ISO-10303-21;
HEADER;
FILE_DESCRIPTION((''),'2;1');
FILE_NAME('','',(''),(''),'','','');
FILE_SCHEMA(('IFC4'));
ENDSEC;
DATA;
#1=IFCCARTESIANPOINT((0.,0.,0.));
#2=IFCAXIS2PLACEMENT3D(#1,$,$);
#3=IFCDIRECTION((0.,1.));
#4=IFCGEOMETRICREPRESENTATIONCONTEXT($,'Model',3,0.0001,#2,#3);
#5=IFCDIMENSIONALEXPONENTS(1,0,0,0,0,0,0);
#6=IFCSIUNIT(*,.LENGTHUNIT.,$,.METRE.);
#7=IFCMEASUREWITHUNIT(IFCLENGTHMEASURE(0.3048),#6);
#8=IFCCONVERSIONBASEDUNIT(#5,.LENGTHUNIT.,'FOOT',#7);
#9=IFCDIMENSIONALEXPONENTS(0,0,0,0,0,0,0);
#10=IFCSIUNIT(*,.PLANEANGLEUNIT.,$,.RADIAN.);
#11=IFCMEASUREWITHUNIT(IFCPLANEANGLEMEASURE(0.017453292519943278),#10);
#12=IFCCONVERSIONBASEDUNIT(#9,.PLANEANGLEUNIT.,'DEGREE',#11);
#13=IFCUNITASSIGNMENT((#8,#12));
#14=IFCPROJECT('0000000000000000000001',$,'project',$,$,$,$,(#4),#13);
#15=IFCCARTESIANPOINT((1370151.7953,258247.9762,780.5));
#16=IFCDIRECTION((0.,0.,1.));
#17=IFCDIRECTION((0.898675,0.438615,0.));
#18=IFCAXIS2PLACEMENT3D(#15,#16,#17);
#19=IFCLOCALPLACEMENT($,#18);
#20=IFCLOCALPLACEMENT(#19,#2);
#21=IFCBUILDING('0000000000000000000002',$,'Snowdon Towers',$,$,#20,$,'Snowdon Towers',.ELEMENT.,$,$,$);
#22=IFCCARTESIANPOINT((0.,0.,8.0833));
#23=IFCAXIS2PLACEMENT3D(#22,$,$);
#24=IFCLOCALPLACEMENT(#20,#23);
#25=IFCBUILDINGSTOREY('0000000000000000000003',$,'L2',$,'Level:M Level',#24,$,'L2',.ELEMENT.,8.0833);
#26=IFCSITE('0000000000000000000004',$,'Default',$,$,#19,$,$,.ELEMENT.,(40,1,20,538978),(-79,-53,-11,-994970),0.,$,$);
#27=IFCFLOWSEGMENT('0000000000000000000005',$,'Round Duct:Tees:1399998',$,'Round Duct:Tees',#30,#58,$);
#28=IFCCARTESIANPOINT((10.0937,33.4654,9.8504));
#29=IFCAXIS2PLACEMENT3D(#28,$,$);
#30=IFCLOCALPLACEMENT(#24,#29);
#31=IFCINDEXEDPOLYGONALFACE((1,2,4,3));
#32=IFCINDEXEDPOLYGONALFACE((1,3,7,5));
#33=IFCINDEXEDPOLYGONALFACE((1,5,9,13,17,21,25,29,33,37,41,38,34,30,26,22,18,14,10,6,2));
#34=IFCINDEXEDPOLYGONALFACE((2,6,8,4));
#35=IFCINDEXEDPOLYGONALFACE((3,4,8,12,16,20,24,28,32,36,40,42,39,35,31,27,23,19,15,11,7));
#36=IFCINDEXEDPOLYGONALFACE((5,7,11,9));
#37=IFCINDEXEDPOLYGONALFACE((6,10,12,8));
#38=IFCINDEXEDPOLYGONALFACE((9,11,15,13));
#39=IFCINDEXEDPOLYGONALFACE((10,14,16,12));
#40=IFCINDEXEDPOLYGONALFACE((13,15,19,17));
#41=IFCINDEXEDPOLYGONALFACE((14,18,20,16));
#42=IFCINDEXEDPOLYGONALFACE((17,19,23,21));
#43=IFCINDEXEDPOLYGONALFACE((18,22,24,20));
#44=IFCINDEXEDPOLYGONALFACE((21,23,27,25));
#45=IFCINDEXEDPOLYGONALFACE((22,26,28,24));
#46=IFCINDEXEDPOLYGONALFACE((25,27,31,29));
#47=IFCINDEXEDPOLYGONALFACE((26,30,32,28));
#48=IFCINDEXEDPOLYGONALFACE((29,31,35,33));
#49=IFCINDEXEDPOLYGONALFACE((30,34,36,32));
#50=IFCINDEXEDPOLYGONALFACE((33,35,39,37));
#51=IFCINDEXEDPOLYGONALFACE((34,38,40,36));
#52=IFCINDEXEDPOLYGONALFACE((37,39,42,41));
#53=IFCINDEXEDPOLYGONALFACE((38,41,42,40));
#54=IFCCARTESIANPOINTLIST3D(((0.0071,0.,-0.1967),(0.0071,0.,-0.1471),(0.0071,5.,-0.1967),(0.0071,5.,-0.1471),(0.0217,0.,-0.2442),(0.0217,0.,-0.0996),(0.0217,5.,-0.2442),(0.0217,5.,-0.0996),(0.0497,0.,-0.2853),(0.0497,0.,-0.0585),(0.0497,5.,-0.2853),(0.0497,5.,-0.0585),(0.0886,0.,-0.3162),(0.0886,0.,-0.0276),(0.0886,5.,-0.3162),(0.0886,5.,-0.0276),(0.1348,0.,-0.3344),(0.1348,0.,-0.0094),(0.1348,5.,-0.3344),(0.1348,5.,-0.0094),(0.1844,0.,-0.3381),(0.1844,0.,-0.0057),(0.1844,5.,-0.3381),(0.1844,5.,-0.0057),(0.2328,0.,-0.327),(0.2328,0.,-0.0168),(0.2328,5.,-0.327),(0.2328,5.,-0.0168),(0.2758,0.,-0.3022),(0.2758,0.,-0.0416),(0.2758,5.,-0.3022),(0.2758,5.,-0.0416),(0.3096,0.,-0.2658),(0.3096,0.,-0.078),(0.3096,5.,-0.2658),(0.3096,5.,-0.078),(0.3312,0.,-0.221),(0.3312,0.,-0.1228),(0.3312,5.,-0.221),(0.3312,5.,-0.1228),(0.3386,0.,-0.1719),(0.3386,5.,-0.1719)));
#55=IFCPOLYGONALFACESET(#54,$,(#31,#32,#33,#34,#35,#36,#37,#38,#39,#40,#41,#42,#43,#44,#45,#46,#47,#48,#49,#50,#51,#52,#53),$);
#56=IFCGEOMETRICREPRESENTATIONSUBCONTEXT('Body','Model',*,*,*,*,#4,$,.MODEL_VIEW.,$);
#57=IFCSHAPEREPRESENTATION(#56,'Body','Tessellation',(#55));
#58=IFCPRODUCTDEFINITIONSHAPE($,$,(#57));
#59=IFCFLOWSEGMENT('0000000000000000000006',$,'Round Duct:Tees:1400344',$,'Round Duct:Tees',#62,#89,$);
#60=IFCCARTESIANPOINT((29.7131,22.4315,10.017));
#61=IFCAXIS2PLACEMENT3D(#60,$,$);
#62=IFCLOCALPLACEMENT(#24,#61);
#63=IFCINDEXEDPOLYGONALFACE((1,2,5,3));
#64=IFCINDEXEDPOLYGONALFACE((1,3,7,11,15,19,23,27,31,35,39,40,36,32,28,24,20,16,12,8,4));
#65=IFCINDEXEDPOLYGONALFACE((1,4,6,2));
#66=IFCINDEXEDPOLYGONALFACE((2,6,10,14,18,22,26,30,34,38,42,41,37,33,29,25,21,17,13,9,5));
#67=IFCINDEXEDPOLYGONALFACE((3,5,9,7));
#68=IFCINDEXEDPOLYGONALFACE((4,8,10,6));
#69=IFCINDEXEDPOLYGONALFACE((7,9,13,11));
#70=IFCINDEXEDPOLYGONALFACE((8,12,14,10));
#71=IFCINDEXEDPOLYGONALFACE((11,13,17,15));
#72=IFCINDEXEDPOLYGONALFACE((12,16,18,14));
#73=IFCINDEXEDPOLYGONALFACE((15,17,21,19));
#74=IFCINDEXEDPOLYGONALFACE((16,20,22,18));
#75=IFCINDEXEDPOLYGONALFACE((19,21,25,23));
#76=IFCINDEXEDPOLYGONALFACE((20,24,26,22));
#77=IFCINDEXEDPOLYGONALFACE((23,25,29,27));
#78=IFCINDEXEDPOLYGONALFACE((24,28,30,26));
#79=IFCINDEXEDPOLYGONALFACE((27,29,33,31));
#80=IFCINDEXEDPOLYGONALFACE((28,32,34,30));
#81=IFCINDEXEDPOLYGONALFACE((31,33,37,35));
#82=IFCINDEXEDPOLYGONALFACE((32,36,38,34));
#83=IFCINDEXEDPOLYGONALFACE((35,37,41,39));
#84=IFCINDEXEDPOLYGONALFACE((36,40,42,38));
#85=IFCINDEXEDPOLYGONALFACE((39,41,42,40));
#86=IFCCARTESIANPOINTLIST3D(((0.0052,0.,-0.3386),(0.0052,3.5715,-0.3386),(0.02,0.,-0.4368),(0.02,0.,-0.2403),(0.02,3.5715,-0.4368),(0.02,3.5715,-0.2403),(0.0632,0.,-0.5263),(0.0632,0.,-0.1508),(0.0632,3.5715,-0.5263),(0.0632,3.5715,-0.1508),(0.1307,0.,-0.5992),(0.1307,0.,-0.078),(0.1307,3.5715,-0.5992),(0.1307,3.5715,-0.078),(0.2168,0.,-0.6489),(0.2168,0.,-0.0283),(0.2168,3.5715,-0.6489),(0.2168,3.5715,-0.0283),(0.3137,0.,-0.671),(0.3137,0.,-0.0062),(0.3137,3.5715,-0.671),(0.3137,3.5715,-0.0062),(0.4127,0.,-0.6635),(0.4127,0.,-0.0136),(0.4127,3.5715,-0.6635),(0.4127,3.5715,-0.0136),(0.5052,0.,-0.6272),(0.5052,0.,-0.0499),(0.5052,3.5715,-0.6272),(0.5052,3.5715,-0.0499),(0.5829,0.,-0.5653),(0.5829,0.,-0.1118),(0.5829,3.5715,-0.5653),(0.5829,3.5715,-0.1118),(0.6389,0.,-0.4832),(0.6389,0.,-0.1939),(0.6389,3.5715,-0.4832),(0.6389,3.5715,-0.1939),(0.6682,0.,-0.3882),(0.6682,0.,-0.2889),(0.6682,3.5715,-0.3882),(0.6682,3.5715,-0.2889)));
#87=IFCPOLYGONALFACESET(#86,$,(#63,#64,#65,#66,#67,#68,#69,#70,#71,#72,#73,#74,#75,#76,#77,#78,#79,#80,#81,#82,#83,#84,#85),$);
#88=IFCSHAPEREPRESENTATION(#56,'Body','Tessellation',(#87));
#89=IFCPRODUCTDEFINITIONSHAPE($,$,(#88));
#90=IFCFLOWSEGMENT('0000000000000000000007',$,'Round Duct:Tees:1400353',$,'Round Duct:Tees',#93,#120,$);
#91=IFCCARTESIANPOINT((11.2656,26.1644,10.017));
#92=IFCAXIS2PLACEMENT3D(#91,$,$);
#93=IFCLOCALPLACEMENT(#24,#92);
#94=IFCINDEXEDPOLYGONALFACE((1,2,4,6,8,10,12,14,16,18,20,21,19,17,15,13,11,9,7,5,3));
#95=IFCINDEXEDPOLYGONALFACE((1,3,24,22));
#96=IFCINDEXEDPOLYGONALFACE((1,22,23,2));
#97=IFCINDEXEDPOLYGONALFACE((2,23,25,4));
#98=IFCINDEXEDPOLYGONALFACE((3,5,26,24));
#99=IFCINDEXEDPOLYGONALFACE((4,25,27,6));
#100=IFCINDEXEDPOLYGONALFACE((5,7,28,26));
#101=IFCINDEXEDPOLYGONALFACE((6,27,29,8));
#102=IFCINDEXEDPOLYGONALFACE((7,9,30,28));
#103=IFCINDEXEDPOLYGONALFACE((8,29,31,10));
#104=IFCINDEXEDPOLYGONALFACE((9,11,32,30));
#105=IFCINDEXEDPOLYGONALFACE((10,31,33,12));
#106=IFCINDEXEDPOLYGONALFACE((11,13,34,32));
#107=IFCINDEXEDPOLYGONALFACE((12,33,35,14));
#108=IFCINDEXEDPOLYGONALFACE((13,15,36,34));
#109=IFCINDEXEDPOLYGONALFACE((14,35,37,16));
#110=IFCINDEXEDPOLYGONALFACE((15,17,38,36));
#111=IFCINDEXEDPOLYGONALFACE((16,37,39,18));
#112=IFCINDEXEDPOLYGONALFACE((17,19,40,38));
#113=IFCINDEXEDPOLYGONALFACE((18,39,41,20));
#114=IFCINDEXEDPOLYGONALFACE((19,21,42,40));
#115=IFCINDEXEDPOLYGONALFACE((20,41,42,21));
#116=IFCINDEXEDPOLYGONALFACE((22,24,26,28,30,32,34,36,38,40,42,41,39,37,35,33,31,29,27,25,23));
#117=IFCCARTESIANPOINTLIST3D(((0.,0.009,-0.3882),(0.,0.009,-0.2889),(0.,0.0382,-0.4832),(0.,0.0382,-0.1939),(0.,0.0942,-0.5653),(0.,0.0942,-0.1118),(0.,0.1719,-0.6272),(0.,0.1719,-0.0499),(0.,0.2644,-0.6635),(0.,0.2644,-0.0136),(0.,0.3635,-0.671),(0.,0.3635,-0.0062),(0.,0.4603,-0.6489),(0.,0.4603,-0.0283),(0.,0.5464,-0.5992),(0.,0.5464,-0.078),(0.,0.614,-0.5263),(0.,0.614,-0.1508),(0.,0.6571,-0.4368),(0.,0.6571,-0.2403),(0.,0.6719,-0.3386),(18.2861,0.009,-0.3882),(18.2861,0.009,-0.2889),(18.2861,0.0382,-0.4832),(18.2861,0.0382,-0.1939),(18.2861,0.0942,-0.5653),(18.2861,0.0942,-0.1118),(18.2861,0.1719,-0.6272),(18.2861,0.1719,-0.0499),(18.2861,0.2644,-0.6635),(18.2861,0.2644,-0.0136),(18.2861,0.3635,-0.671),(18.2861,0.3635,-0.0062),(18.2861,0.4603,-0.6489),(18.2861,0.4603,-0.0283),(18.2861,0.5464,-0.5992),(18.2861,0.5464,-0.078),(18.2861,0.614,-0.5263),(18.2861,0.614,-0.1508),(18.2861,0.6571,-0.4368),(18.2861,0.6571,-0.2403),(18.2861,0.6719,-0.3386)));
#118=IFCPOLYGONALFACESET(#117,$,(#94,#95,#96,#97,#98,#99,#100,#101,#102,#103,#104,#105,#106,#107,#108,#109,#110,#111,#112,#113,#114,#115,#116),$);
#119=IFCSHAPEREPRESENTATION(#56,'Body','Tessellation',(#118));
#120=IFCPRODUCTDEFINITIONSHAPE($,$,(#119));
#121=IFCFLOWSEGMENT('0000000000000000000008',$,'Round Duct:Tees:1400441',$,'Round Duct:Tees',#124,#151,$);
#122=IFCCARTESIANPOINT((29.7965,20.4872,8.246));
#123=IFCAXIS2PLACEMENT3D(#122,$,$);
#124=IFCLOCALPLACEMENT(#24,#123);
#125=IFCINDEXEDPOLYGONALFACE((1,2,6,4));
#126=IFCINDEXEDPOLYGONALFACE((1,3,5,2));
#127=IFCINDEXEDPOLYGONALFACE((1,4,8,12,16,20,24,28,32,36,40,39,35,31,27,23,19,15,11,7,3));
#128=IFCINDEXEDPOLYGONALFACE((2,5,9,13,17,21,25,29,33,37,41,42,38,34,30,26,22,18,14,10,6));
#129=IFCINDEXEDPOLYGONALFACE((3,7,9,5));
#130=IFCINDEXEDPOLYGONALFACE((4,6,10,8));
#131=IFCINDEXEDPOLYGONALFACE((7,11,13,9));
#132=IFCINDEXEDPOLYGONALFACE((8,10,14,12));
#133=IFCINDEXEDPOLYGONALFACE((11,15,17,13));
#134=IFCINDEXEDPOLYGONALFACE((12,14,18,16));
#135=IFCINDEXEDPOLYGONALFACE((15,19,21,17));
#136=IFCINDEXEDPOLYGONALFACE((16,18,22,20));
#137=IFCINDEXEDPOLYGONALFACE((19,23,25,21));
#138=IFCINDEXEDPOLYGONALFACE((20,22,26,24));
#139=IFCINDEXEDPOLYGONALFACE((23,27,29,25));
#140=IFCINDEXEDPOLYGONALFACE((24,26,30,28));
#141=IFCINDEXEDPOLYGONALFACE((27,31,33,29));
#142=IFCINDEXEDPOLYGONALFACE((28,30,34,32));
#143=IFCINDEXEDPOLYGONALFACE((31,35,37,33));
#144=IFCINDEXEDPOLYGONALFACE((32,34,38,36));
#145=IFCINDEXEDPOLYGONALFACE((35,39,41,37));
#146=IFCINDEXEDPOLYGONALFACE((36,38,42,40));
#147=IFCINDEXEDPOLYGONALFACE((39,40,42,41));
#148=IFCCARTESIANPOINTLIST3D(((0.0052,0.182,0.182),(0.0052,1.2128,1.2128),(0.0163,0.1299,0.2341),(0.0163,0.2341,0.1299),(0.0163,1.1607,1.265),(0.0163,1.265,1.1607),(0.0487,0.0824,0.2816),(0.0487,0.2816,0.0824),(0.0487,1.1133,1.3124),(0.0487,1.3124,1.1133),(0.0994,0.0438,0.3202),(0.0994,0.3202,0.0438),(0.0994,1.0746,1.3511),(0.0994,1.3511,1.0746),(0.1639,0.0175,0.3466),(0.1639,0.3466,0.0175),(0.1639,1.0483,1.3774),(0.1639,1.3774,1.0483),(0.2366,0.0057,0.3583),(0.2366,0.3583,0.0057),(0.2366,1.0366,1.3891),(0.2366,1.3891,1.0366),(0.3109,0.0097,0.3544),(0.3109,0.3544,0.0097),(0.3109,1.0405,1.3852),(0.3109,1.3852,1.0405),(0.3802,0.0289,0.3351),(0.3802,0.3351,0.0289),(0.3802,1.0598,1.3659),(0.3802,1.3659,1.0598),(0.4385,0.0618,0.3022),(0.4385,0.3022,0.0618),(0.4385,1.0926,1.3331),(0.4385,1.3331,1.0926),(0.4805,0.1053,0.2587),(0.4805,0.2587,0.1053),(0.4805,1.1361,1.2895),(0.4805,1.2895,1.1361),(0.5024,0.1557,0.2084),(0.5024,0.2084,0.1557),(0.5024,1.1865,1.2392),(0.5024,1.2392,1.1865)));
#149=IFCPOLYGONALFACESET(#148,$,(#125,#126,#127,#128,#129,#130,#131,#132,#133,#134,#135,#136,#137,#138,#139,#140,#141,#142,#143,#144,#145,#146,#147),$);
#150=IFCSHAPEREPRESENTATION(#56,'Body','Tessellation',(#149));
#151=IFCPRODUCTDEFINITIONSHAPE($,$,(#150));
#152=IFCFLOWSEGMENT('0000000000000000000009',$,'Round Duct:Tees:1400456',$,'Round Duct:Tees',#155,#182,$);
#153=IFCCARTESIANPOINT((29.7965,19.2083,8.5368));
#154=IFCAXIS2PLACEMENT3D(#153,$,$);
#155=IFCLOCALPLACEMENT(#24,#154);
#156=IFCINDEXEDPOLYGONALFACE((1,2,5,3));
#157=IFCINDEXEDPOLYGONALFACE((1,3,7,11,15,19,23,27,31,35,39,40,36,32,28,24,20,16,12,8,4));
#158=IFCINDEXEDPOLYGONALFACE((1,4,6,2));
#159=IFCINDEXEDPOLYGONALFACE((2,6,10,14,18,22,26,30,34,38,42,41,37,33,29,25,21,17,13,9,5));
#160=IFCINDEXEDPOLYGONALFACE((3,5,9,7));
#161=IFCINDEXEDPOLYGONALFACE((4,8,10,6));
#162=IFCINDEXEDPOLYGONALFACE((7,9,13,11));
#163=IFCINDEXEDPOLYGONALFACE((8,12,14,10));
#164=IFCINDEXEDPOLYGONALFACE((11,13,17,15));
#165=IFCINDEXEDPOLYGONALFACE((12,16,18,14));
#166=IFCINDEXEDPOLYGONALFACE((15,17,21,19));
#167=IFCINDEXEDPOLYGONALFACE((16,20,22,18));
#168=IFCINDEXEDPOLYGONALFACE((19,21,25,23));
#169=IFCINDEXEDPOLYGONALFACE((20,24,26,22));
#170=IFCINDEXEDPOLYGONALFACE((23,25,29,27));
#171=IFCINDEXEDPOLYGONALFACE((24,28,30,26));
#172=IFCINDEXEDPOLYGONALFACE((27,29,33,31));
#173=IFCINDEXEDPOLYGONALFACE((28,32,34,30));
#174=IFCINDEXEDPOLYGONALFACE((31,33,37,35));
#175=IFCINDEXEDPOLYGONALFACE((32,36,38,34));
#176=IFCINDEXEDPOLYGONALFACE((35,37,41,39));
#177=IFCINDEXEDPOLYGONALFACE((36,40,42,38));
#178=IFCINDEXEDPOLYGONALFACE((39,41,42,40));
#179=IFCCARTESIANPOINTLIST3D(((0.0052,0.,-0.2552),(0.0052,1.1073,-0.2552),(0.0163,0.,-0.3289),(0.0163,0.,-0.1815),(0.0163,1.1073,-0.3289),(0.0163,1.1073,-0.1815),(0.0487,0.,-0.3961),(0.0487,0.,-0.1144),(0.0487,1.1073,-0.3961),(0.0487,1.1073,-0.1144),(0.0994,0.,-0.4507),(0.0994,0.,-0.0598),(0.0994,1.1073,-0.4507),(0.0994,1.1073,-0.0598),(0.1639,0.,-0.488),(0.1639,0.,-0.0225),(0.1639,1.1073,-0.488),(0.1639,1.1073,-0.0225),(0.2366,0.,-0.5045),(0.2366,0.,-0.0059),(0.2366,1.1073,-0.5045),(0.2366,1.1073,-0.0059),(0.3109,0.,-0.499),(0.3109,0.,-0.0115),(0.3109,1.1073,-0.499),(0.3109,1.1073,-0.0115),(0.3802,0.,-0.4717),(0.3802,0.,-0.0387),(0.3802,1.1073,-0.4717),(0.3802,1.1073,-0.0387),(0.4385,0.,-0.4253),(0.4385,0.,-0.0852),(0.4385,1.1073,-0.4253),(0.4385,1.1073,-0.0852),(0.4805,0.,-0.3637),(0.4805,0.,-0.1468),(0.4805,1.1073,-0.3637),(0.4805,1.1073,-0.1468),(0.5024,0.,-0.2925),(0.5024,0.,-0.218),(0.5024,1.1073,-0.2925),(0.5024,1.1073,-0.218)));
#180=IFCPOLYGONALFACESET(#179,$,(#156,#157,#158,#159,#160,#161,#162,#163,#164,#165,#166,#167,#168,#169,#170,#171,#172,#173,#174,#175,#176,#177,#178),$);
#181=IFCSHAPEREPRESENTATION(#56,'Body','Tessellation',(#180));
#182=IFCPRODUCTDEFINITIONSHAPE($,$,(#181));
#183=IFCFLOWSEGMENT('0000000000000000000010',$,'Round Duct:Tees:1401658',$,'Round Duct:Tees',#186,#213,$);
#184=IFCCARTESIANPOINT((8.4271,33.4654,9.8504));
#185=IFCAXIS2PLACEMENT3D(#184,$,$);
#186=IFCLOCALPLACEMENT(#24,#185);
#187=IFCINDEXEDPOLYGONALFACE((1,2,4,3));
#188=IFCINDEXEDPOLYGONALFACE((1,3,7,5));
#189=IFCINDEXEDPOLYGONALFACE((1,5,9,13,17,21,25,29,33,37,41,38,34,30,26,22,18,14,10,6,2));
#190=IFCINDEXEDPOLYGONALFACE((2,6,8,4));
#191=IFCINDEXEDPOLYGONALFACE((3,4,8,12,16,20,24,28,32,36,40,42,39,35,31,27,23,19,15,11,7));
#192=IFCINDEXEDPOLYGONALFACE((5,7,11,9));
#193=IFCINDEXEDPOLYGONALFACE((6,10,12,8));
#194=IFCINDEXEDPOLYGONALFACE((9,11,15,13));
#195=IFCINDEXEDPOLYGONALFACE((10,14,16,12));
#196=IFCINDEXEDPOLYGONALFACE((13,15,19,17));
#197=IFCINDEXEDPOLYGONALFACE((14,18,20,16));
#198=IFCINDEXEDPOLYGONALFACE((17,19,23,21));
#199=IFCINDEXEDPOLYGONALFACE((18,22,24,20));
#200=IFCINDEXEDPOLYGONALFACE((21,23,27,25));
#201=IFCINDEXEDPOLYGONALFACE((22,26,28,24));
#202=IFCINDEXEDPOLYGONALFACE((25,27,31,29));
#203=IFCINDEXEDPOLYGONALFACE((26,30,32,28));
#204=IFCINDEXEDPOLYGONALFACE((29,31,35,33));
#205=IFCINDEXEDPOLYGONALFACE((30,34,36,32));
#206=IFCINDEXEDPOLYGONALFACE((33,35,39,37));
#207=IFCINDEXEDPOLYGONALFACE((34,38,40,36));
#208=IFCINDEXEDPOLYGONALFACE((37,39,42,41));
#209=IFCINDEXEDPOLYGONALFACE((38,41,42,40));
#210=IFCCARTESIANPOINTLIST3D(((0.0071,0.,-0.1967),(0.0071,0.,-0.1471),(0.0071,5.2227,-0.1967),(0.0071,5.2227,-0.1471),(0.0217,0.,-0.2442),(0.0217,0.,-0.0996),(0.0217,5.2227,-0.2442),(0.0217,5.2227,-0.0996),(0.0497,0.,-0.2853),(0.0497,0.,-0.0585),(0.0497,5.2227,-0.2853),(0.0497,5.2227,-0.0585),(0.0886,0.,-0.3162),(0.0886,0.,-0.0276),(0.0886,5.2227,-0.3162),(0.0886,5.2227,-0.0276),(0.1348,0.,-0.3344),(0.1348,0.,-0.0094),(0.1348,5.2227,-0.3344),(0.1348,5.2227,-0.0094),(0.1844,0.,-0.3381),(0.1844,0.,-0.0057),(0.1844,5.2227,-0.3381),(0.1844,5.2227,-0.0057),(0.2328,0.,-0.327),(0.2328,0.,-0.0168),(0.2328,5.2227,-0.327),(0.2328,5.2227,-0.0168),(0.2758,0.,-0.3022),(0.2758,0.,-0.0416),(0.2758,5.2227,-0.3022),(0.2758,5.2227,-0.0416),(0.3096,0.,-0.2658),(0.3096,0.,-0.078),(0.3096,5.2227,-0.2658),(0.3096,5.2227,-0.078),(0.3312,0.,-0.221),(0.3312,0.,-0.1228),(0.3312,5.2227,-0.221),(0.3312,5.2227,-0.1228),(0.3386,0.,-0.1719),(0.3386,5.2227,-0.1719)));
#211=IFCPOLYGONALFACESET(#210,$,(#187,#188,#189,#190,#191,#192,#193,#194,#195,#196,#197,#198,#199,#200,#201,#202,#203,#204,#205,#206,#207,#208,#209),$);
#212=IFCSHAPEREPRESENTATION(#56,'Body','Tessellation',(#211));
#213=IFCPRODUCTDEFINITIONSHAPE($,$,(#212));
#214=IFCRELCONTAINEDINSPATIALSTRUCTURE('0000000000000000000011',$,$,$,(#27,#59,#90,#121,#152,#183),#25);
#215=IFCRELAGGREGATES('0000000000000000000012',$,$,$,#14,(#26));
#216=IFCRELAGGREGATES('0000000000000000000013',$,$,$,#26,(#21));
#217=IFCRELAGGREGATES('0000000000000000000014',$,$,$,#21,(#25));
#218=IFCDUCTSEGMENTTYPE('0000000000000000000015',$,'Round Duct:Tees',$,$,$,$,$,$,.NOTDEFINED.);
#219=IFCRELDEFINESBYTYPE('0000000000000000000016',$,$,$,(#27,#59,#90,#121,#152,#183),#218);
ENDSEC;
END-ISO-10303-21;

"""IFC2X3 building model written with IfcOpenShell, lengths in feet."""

from ifc_helpers import new_model, entity, si_unit, converted_unit, direction, frame, frame_2d, origin, origin_2d_with_axis, place, context, subcontext, project, spatial, circle, extrude, type_object, element, save


model = new_model("IFC2X3")

# Units and contexts
model_context = context("Model", 3, precision=0.0001, world=origin(), true_north=direction((0.0, 1.0)))
body_context = subcontext(model_context, "Body", "Model", "MODEL_VIEW")
ifc_project = project(units=[converted_unit("LENGTHUNIT", "FOOT", entity("IfcLengthMeasure", 0.3048), si_unit("LENGTHUNIT", "METRE"), dimensions=[1, 0, 0, 0, 0, 0, 0]), converted_unit("PLANEANGLEUNIT", "DEGREE", entity("IfcPlaneAngleMeasure", 0.017453292519943278), si_unit("PLANEANGLEUNIT", "RADIAN"), dimensions=[0, 0, 0, 0, 0, 0, 0])], contexts=[model_context])

# Site, building, storey
site_placement = place(None, frame((1370151.7953, 258247.9762, 780.5), z_axis=(0.0, 0.0, 1.0), x_axis=(0.898675, 0.438615, 0.0)))
site = spatial("IfcSite", under=ifc_project, at=site_placement, Name="Default", CompositionType="ELEMENT", RefLatitude=(40, 1, 20, 538978), RefLongitude=(-79, -53, -11, -994970), RefElevation=0.0)
building_placement = place(site_placement, origin())
building = spatial("IfcBuilding", under=site, at=building_placement, Name="Snowdon Towers", LongName="Snowdon Towers", CompositionType="ELEMENT")
storey_placement = place(building_placement, frame((0.0, 0.0, 8.0833)))
storey = spatial("IfcBuildingStorey", under=building, at=storey_placement, Name="L2", ObjectType="Level:M Level", LongName="L2", CompositionType="ELEMENT", Elevation=8.0833)

# Flow segments
duct_segment_type = type_object("IfcDuctSegmentType", Name="Round Duct:Tees", PredefinedType="NOTDEFINED")
flow_segment_1_placement = place(storey_placement, frame((10.0937, 33.4654, 9.8504)))
element("IfcFlowSegment", 1, at=flow_segment_1_placement, inside=storey, type_object=duct_segment_type, Name="Round Duct:Tees:1399998", ObjectType="Round Duct:Tees", context=body_context, shape_type="SweptSolid", body=[
    extrude(circle(Radius=0.1667, at=origin_2d_with_axis()), frame((0.1719, 0.0, -0.1719), z_axis=(0.0, 1.0, 0.0), x_axis=(1.0, 0.0, 0.0)), (0.0, 0.0, 1.0), 5.0),
])
flow_segment_2_placement = place(storey_placement, frame((29.7131, 22.4315, 10.017)))
element("IfcFlowSegment", 2, at=flow_segment_2_placement, inside=storey, type_object=duct_segment_type, Name="Round Duct:Tees:1400344", ObjectType="Round Duct:Tees", context=body_context, shape_type="SweptSolid", body=[
    extrude(circle(Radius=0.3333, at=frame_2d((0.0, 0.0), x_axis=(1.0, 0.0))), frame((0.3386, 0.0, -0.3386), z_axis=(0.0, 1.0, 0.0), x_axis=(-1.0, 0.0, 0.0)), (0.0, 0.0, 1.0), 3.5715),
])
flow_segment_3_placement = place(storey_placement, frame((11.2656, 26.1644, 10.017)))
element("IfcFlowSegment", 3, at=flow_segment_3_placement, inside=storey, type_object=duct_segment_type, Name="Round Duct:Tees:1400353", ObjectType="Round Duct:Tees", context=body_context, shape_type="SweptSolid", body=[
    extrude(circle(Radius=0.3333, at=frame_2d((0.0, 0.0), x_axis=(1.0, 0.0))), frame((0.0, 0.3386, -0.3386), z_axis=(1.0, 0.0, 0.0), x_axis=(0.0, 1.0, 0.0)), (0.0, 0.0, 1.0), 18.2861),
])
flow_segment_4_placement = place(storey_placement, frame((29.7965, 20.4872, 8.246)))
element("IfcFlowSegment", 4, at=flow_segment_4_placement, inside=storey, type_object=duct_segment_type, Name="Round Duct:Tees:1400441", ObjectType="Round Duct:Tees", context=body_context, shape_type="SweptSolid", body=[
    extrude(circle(Radius=0.25, at=frame_2d((0.0, 0.0), x_axis=(1.0, 0.0))), frame((0.2552, 0.182, 0.182), z_axis=(0.0, 0.707107, 0.707107), x_axis=(-1.0, 0.0, 0.0)), (0.0, 0.0, 1.0), 1.4578),
])
flow_segment_5_placement = place(storey_placement, frame((29.7965, 19.2083, 8.5368)))
element("IfcFlowSegment", 5, at=flow_segment_5_placement, inside=storey, type_object=duct_segment_type, Name="Round Duct:Tees:1400456", ObjectType="Round Duct:Tees", context=body_context, shape_type="SweptSolid", body=[
    extrude(circle(Radius=0.25, at=frame_2d((0.0, 0.0), x_axis=(1.0, 0.0))), frame((0.2552, 0.0, -0.2552), z_axis=(0.0, 1.0, 0.0), x_axis=(-1.0, 0.0, 0.0)), (0.0, 0.0, 1.0), 1.1073),
])
flow_segment_6_placement = place(storey_placement, frame((8.4271, 33.4654, 9.8504)))
element("IfcFlowSegment", 6, at=flow_segment_6_placement, inside=storey, type_object=duct_segment_type, Name="Round Duct:Tees:1401658", ObjectType="Round Duct:Tees", context=body_context, shape_type="SweptSolid", body=[
    extrude(circle(Radius=0.1667, at=origin_2d_with_axis()), frame((0.1719, 0.0, -0.1719), z_axis=(0.0, 1.0, 0.0), x_axis=(1.0, 0.0, 0.0)), (0.0, 0.0, 1.0), 5.2227),
])

save(model, "model.ifc")
